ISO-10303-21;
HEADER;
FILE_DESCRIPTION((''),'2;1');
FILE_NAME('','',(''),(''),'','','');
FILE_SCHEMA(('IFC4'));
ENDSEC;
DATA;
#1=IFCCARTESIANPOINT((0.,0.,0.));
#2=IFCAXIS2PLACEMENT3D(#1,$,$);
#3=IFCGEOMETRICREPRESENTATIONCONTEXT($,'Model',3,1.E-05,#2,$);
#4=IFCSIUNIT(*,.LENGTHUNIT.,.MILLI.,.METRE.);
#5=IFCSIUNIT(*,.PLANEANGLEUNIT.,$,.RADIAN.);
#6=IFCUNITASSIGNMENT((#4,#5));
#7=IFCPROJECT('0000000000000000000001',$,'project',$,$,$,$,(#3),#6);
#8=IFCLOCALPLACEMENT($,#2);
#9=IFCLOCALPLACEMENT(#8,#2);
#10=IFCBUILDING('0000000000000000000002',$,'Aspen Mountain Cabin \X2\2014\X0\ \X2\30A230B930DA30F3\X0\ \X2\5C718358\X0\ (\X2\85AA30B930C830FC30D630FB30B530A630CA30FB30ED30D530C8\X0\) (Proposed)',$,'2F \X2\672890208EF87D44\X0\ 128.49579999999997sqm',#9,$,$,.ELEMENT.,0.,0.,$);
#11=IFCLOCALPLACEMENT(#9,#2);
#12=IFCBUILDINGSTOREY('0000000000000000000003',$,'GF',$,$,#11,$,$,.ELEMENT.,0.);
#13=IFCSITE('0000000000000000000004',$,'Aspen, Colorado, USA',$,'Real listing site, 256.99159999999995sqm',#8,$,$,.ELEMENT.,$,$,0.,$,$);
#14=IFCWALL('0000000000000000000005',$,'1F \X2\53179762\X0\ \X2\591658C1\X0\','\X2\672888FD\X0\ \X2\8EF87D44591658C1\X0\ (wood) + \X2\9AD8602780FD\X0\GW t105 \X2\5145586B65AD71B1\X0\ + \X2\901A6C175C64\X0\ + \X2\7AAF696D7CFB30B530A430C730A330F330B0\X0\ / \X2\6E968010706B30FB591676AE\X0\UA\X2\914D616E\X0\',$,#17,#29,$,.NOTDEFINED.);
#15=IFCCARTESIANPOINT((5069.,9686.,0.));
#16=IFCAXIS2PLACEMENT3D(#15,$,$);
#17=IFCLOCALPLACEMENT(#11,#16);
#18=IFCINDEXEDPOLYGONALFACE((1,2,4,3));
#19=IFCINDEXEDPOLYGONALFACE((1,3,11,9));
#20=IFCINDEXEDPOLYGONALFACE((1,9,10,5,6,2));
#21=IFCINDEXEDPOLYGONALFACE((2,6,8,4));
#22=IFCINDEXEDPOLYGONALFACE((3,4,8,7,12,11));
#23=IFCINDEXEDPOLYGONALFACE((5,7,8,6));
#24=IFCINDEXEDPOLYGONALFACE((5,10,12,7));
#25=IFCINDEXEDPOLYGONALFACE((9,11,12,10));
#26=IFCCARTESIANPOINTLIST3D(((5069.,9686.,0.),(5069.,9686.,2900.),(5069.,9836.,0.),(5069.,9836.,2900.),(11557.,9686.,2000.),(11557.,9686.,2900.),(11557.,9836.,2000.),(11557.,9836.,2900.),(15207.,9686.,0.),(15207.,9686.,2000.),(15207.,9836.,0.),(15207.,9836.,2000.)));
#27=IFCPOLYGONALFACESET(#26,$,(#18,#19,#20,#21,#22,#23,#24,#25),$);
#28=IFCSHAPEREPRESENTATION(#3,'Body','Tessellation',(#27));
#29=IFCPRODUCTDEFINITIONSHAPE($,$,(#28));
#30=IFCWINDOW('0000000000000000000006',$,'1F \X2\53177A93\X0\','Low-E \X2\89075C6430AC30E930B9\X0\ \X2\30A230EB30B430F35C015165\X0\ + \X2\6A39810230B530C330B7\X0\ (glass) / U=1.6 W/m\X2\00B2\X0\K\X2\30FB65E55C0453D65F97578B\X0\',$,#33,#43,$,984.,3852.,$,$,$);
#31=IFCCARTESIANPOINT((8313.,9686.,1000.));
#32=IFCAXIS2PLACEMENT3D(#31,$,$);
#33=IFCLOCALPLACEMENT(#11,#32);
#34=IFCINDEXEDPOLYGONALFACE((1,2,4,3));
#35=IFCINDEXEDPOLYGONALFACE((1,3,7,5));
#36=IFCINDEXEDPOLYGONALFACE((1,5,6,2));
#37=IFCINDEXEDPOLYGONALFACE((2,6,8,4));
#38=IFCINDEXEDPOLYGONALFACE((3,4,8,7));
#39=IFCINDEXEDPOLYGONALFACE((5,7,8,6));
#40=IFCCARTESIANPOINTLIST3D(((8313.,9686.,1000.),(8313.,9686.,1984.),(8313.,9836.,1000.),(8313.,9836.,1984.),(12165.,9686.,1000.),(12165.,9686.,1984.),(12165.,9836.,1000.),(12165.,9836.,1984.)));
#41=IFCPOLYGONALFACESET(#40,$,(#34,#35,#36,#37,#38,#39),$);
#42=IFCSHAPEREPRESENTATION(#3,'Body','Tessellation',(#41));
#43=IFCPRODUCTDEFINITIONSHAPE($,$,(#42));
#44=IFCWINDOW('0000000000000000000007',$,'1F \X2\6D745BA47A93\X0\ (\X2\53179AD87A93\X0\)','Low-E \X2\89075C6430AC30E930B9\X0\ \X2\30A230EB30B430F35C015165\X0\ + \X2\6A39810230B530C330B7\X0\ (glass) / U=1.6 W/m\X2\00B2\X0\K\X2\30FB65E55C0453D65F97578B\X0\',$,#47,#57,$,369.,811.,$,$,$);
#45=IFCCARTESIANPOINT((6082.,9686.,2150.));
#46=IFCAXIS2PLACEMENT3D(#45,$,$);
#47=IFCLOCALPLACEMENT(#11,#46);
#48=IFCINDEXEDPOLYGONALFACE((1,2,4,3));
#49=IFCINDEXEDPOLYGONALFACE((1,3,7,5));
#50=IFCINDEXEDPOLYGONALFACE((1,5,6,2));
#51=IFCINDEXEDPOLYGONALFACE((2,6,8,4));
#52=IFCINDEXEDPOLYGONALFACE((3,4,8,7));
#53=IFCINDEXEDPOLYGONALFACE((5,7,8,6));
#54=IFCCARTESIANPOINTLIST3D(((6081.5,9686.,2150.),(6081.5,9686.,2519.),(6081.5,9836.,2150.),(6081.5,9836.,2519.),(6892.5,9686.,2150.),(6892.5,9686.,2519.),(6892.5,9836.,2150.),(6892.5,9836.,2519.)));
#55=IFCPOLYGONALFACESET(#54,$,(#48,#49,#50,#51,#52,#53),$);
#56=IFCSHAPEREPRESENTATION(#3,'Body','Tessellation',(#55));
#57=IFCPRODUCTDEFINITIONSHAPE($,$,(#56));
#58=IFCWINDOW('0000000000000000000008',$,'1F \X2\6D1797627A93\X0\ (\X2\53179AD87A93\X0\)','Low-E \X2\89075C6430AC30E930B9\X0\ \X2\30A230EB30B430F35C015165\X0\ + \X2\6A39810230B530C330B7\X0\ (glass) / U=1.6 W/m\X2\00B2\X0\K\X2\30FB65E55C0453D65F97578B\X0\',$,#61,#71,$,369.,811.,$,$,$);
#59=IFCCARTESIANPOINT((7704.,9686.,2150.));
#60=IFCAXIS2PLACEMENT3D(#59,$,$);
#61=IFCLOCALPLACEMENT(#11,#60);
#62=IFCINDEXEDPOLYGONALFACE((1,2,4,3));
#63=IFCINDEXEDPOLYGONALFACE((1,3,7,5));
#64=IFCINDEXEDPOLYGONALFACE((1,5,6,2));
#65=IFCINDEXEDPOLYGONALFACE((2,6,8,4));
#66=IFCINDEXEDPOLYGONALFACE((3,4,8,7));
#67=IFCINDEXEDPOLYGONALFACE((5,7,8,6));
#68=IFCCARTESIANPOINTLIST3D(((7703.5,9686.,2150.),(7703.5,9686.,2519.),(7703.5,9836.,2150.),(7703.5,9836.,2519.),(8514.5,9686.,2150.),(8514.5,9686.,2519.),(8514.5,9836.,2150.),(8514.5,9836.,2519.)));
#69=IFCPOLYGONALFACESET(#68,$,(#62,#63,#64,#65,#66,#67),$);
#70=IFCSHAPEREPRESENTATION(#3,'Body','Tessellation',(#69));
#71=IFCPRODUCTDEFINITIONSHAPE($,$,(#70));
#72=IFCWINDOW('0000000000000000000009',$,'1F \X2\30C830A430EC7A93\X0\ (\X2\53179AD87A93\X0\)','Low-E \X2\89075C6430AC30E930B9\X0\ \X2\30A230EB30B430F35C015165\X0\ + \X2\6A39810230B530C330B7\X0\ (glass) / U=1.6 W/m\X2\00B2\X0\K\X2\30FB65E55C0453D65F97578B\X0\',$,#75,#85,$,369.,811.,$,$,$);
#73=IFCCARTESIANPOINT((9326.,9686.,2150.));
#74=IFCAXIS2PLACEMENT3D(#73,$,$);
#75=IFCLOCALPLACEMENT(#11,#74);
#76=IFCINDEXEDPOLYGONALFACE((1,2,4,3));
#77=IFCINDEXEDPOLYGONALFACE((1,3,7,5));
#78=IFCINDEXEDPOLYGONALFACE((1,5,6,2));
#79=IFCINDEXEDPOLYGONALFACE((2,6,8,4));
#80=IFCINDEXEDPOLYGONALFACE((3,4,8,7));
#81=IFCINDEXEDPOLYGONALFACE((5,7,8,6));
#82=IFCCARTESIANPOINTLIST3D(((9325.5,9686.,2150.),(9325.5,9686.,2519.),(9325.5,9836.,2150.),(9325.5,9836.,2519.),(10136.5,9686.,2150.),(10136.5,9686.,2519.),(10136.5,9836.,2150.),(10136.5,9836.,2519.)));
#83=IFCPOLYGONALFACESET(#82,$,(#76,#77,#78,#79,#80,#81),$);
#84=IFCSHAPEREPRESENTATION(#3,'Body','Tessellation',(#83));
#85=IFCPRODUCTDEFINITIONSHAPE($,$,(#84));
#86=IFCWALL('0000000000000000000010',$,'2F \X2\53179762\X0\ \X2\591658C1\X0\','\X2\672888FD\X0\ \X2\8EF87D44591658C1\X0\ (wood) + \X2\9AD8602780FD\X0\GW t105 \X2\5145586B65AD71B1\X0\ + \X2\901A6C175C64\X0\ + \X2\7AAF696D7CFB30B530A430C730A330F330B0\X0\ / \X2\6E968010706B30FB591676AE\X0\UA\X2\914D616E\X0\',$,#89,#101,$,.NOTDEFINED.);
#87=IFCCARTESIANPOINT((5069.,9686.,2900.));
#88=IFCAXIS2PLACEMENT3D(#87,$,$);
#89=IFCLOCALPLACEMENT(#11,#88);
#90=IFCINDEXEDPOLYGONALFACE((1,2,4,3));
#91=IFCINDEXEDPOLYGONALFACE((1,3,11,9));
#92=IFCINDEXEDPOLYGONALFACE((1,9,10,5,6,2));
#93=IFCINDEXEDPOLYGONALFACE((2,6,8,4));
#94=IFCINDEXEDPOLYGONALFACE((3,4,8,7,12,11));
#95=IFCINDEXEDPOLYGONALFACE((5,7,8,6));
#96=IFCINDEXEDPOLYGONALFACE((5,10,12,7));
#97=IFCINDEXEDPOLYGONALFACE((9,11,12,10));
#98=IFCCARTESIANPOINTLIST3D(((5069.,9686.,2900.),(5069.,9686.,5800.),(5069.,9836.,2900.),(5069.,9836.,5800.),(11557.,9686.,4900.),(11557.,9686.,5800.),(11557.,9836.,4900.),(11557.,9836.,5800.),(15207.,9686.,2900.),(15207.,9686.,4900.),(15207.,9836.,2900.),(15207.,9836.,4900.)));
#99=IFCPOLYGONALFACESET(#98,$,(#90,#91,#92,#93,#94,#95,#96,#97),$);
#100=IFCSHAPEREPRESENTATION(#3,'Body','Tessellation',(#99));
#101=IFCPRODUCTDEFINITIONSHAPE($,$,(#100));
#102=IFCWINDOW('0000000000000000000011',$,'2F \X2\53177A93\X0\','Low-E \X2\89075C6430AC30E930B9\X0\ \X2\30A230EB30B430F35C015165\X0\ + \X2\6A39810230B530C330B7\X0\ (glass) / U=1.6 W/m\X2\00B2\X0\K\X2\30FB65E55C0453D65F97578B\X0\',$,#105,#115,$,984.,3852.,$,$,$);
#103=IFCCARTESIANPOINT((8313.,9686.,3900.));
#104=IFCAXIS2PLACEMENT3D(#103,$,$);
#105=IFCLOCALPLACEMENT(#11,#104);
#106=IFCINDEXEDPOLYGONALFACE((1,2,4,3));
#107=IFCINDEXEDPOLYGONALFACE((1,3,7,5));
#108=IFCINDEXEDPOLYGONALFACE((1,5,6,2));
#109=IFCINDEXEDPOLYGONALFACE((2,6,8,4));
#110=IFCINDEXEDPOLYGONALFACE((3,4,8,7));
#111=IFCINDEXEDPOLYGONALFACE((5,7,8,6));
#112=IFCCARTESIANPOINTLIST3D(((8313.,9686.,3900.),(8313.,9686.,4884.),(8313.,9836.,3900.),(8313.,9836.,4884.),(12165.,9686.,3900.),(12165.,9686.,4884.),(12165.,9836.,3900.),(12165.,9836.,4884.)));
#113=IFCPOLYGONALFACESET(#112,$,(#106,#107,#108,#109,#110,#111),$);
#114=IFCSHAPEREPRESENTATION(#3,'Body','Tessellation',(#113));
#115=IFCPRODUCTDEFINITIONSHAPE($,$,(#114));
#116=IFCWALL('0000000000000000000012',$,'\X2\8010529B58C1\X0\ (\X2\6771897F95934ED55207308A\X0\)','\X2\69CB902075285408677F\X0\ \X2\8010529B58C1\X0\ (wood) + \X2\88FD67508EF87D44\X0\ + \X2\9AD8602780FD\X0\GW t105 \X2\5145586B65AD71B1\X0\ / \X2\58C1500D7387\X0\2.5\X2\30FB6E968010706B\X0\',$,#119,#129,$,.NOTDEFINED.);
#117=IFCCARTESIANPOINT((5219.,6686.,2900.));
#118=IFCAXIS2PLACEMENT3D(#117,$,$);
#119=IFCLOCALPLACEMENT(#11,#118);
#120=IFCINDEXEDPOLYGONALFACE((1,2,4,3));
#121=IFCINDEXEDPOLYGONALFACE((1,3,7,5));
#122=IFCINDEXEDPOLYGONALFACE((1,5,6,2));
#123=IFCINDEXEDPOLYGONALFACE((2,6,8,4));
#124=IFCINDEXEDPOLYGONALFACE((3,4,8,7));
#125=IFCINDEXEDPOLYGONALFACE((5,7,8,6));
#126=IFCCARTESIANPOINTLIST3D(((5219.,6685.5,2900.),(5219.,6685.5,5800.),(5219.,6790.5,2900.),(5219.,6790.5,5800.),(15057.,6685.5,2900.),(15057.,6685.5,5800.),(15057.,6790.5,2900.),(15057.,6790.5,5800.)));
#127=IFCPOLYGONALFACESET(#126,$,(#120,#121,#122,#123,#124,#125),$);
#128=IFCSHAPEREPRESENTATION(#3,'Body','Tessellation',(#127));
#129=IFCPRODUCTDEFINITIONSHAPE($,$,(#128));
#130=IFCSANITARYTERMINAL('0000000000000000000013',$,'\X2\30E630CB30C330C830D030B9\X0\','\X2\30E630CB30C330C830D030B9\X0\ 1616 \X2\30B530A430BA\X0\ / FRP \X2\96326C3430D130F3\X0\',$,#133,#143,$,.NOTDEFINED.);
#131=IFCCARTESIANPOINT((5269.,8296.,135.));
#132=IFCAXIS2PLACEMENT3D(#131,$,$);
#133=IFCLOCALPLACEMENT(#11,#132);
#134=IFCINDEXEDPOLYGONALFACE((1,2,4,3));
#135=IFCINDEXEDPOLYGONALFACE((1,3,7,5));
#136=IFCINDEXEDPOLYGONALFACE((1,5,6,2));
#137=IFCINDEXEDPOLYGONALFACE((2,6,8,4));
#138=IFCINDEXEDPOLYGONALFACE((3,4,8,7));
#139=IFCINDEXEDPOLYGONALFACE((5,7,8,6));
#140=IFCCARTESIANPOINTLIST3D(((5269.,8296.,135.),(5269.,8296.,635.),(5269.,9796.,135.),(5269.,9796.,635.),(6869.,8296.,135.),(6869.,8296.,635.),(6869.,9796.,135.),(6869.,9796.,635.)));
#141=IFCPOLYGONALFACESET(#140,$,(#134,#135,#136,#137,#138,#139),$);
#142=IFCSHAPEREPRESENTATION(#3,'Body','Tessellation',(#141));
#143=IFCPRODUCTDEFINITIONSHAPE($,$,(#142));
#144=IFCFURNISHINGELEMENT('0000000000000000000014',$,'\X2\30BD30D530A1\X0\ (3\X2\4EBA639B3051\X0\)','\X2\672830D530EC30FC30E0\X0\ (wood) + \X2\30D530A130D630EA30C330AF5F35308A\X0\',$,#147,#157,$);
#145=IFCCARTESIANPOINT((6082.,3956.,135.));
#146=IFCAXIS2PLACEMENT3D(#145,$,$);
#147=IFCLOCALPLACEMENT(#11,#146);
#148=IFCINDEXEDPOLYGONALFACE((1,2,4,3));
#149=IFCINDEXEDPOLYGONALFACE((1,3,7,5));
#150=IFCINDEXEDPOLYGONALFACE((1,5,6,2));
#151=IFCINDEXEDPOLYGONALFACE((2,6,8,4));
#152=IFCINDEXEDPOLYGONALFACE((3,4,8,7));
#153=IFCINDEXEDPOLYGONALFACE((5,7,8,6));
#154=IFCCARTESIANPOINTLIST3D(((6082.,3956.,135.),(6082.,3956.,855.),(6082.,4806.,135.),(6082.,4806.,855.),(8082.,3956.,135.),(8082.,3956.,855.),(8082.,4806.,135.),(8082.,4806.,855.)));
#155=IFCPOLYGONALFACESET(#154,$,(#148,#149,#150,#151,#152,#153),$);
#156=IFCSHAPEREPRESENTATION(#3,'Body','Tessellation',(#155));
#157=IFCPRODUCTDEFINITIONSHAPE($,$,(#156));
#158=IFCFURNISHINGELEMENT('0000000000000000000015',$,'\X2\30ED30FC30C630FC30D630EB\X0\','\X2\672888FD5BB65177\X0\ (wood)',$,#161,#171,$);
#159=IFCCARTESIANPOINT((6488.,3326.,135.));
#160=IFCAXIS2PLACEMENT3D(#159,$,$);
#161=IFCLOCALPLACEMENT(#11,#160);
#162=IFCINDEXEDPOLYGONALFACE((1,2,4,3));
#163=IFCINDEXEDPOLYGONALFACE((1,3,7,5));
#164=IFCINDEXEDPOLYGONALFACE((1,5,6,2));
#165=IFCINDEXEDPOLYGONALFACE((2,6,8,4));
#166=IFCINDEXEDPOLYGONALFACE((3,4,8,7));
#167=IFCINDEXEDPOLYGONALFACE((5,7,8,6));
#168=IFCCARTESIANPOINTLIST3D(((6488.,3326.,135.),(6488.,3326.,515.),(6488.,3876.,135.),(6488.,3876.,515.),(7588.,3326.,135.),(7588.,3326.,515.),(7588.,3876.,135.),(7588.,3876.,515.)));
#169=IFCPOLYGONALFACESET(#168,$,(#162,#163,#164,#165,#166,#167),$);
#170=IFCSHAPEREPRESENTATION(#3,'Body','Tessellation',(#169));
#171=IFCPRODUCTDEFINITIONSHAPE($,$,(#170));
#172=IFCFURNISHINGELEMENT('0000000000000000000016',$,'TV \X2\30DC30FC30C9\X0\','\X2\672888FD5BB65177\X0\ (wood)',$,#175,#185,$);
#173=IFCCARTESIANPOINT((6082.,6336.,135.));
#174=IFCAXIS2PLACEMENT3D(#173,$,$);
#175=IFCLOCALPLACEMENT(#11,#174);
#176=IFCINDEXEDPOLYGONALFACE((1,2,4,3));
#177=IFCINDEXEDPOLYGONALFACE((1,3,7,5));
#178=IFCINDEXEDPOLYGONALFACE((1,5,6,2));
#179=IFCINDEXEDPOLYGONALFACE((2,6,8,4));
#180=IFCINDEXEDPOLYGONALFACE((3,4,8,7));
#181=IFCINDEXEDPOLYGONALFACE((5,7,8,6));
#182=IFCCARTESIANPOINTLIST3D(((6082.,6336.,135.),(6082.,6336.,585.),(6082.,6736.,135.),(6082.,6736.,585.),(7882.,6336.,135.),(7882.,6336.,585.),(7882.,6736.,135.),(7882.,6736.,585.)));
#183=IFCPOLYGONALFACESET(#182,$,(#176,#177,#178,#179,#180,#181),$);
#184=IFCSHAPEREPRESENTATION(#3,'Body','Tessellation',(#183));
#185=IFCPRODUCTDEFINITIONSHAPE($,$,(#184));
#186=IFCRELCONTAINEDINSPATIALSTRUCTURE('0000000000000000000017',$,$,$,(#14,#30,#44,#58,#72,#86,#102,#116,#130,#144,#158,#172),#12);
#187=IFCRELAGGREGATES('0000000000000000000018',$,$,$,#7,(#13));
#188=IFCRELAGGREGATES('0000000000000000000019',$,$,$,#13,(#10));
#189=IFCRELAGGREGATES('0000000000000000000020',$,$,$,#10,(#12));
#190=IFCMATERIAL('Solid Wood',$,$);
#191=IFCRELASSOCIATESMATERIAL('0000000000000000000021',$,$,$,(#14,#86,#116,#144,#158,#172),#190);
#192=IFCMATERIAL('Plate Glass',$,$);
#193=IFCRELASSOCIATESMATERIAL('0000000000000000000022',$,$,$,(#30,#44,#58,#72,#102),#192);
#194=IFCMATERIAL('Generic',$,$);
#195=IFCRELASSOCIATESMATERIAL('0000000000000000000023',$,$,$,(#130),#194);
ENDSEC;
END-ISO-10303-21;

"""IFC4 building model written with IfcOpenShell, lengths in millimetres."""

from ifc_helpers import new_model, si_unit, frame, frame_2d, origin, place, context, project, spatial, rectangle, extrude, material, element, fill, save


model = new_model("IFC4")

# Units and contexts
model_context = context("Model", 3, precision=1e-05, world=origin())
ifc_project = project(units=[si_unit("LENGTHUNIT", "METRE", prefix="MILLI"), si_unit("PLANEANGLEUNIT", "RADIAN")], contexts=[model_context])

# Site, building, storey
site_placement = place(None, origin())
site = spatial("IfcSite", under=ifc_project, at=site_placement, Name="Aspen, Colorado, USA", ObjectType="Real listing site, 256.99159999999995sqm", CompositionType="ELEMENT", RefElevation=0.0)
building_placement = place(site_placement, origin())
building = spatial("IfcBuilding", under=site, at=building_placement, Name="Aspen Mountain Cabin — アスペン 山荘 (薪ストーブ・サウナ・ロフト) (Proposed)", ObjectType="2F 木造軸組 128.49579999999997sqm", CompositionType="ELEMENT", ElevationOfRefHeight=0.0, ElevationOfTerrain=0.0)
storey_placement = place(building_placement, origin())
storey = spatial("IfcBuildingStorey", under=building, at=storey_placement, Name="GF", CompositionType="ELEMENT", Elevation=0.0)

# Wall, openings, windows
ifc_material_1 = material(Name="Solid Wood")
wall_1_placement = place(storey_placement, frame((5069.0, 9686.0, 0.0)))
wall_1 = element("IfcWall", 1, at=wall_1_placement, inside=storey, material=ifc_material_1, Name="1F 北面 外壁", Description="木製 軸組外壁 (wood) + 高性能GW t105 充填断熱 + 通気層 + 窯業系サイディング / 準耐火・外皮UA配慮", PredefinedType="NOTDEFINED", context=model_context, shape_type="SweptSolid", body=[
    extrude(rectangle(XDim=10138.0, YDim=150.0, at=frame_2d((5069.0, 75.0))), frame((5069.0, 9686.0, 0.0)), (0.0, 0.0, 1.0), 2900.0),
])
opening_1_placement = place(storey_placement, frame((8313.0, 9686.0, 1000.0)))
opening_1 = element("IfcOpeningElement", 2, at=opening_1_placement, cuts=wall_1, PredefinedType="NOTDEFINED", context=model_context, shape_type="SweptSolid", body=[
    extrude(rectangle(XDim=3852.0, YDim=150.0, at=frame_2d((1926.0, 75.0))), frame((8313.0, 9686.0, 1000.0)), (0.0, 0.0, 1.0), 984.0),
])
opening_2_placement = place(storey_placement, frame((6082.0, 9686.0, 2150.0)))
opening_2 = element("IfcOpeningElement", 3, at=opening_2_placement, cuts=wall_1, PredefinedType="NOTDEFINED", context=model_context, shape_type="SweptSolid", body=[
    extrude(rectangle(XDim=811.0, YDim=150.0, at=frame_2d((405.0, 75.0))), frame((6082.0, 9686.0, 2150.0)), (0.0, 0.0, 1.0), 369.0),
])
opening_3_placement = place(storey_placement, frame((7704.0, 9686.0, 2150.0)))
opening_3 = element("IfcOpeningElement", 4, at=opening_3_placement, cuts=wall_1, PredefinedType="NOTDEFINED", context=model_context, shape_type="SweptSolid", body=[
    extrude(rectangle(XDim=811.0, YDim=150.0, at=frame_2d((405.0, 75.0))), frame((7704.0, 9686.0, 2150.0)), (0.0, 0.0, 1.0), 369.0),
])
opening_4_placement = place(storey_placement, frame((9326.0, 9686.0, 2150.0)))
opening_4 = element("IfcOpeningElement", 5, at=opening_4_placement, cuts=wall_1, PredefinedType="NOTDEFINED", context=model_context, shape_type="SweptSolid", body=[
    extrude(rectangle(XDim=811.0, YDim=150.0, at=frame_2d((405.0, 75.0))), frame((9326.0, 9686.0, 2150.0)), (0.0, 0.0, 1.0), 369.0),
])
ifc_material_2 = material(Name="Plate Glass")
window_1_placement = place(storey_placement, frame((8313.0, 9686.0, 1000.0)))
window_1 = element("IfcWindow", 6, at=window_1_placement, inside=storey, material=ifc_material_2, Name="1F 北窓", Description="Low-E 複層ガラス アルゴン封入 + 樹脂サッシ (glass) / U=1.6 W/m²K・日射取得型", OverallHeight=984.0, OverallWidth=3852.0, context=model_context, shape_type="SweptSolid", body=[
    extrude(rectangle(XDim=3852.0, YDim=150.0, at=frame_2d((1926.0, 75.0))), frame((8313.0, 9686.0, 1000.0)), (0.0, 0.0, 1.0), 984.0),
])
fill(opening_1, window_1)
window_2_placement = place(storey_placement, frame((6082.0, 9686.0, 2150.0)))
window_2 = element("IfcWindow", 7, at=window_2_placement, inside=storey, material=ifc_material_2, Name="1F 浴室窓 (北高窓)", Description="Low-E 複層ガラス アルゴン封入 + 樹脂サッシ (glass) / U=1.6 W/m²K・日射取得型", OverallHeight=369.0, OverallWidth=811.0, context=model_context, shape_type="SweptSolid", body=[
    extrude(rectangle(XDim=811.0, YDim=150.0, at=frame_2d((405.0, 75.0))), frame((6082.0, 9686.0, 2150.0)), (0.0, 0.0, 1.0), 369.0),
])
fill(opening_2, window_2)
window_3_placement = place(storey_placement, frame((7704.0, 9686.0, 2150.0)))
window_3 = element("IfcWindow", 8, at=window_3_placement, inside=storey, material=ifc_material_2, Name="1F 洗面窓 (北高窓)", Description="Low-E 複層ガラス アルゴン封入 + 樹脂サッシ (glass) / U=1.6 W/m²K・日射取得型", OverallHeight=369.0, OverallWidth=811.0, context=model_context, shape_type="SweptSolid", body=[
    extrude(rectangle(XDim=811.0, YDim=150.0, at=frame_2d((405.0, 75.0))), frame((7704.0, 9686.0, 2150.0)), (0.0, 0.0, 1.0), 369.0),
])
fill(opening_3, window_3)
window_4_placement = place(storey_placement, frame((9326.0, 9686.0, 2150.0)))
window_4 = element("IfcWindow", 9, at=window_4_placement, inside=storey, material=ifc_material_2, Name="1F トイレ窓 (北高窓)", Description="Low-E 複層ガラス アルゴン封入 + 樹脂サッシ (glass) / U=1.6 W/m²K・日射取得型", OverallHeight=369.0, OverallWidth=811.0, context=model_context, shape_type="SweptSolid", body=[
    extrude(rectangle(XDim=811.0, YDim=150.0, at=frame_2d((405.0, 75.0))), frame((9326.0, 9686.0, 2150.0)), (0.0, 0.0, 1.0), 369.0),
])
fill(opening_4, window_4)

# Wall, opening, window
wall_2_placement = place(storey_placement, frame((5069.0, 9686.0, 2900.0)))
wall_2 = element("IfcWall", 10, at=wall_2_placement, inside=storey, material=ifc_material_1, Name="2F 北面 外壁", Description="木製 軸組外壁 (wood) + 高性能GW t105 充填断熱 + 通気層 + 窯業系サイディング / 準耐火・外皮UA配慮", PredefinedType="NOTDEFINED", context=model_context, shape_type="SweptSolid", body=[
    extrude(rectangle(XDim=10138.0, YDim=150.0, at=frame_2d((5069.0, 75.0))), frame((5069.0, 9686.0, 2900.0)), (0.0, 0.0, 1.0), 2900.0),
])
opening_5_placement = place(storey_placement, frame((8313.0, 9686.0, 3900.0)))
opening_5 = element("IfcOpeningElement", 11, at=opening_5_placement, cuts=wall_2, PredefinedType="NOTDEFINED", context=model_context, shape_type="SweptSolid", body=[
    extrude(rectangle(XDim=3852.0, YDim=150.0, at=frame_2d((1926.0, 75.0))), frame((8313.0, 9686.0, 3900.0)), (0.0, 0.0, 1.0), 984.0),
])
window_5_placement = place(storey_placement, frame((8313.0, 9686.0, 3900.0)))
window_5 = element("IfcWindow", 12, at=window_5_placement, inside=storey, material=ifc_material_2, Name="2F 北窓", Description="Low-E 複層ガラス アルゴン封入 + 樹脂サッシ (glass) / U=1.6 W/m²K・日射取得型", OverallHeight=984.0, OverallWidth=3852.0, context=model_context, shape_type="SweptSolid", body=[
    extrude(rectangle(XDim=3852.0, YDim=150.0, at=frame_2d((1926.0, 75.0))), frame((8313.0, 9686.0, 3900.0)), (0.0, 0.0, 1.0), 984.0),
])
fill(opening_5, window_5)

# Wall
wall_3_placement = place(storey_placement, frame((5219.0, 6686.0, 2900.0)))
element("IfcWall", 13, at=wall_3_placement, inside=storey, material=ifc_material_1, Name="耐力壁 (東西間仕切り)", Description="構造用合板 耐力壁 (wood) + 製材軸組 + 高性能GW t105 充填断熱 / 壁倍率2.5・準耐火", PredefinedType="NOTDEFINED", context=model_context, shape_type="SweptSolid", body=[
    extrude(rectangle(XDim=9838.0, YDim=105.0, at=frame_2d((4919.0, 52.0))), frame((5219.0, 6686.0, 2900.0)), (0.0, 0.0, 1.0), 2900.0),
])

# Sanitary terminal
ifc_material_3 = material(Name="Generic")
sanitary_terminal_placement = place(storey_placement, frame((5269.0, 8296.0, 135.0)))
element("IfcSanitaryTerminal", 14, at=sanitary_terminal_placement, inside=storey, material=ifc_material_3, Name="ユニットバス", Description="ユニットバス 1616 サイズ / FRP 防水パン", PredefinedType="NOTDEFINED", context=model_context, shape_type="SweptSolid", body=[
    extrude(rectangle(XDim=1600.0, YDim=1500.0, at=frame_2d((800.0, 750.0))), frame((5269.0, 8296.0, 135.0)), (0.0, 0.0, 1.0), 500.0),
])

# Furnishing elements
furnishing_1_placement = place(storey_placement, frame((6082.0, 3956.0, 135.0)))
element("IfcFurnishingElement", 15, at=furnishing_1_placement, inside=storey, material=ifc_material_1, Name="ソファ (3人掛け)", Description="木フレーム (wood) + ファブリック張り", context=model_context, shape_type="SweptSolid", body=[
    extrude(rectangle(XDim=2000.0, YDim=850.0, at=frame_2d((1000.0, 425.0))), frame((6082.0, 3956.0, 135.0)), (0.0, 0.0, 1.0), 720.0),
])
furnishing_2_placement = place(storey_placement, frame((6488.0, 3326.0, 135.0)))
element("IfcFurnishingElement", 16, at=furnishing_2_placement, inside=storey, material=ifc_material_1, Name="ローテーブル", Description="木製家具 (wood)", context=model_context, shape_type="SweptSolid", body=[
    extrude(rectangle(XDim=1100.0, YDim=550.0, at=frame_2d((550.0, 275.0))), frame((6488.0, 3326.0, 135.0)), (0.0, 0.0, 1.0), 380.0),
])
furnishing_3_placement = place(storey_placement, frame((6082.0, 6336.0, 135.0)))
element("IfcFurnishingElement", 17, at=furnishing_3_placement, inside=storey, material=ifc_material_1, Name="TV ボード", Description="木製家具 (wood)", context=model_context, shape_type="SweptSolid", body=[
    extrude(rectangle(XDim=1800.0, YDim=400.0, at=frame_2d((900.0, 200.0))), frame((6082.0, 6336.0, 135.0)), (0.0, 0.0, 1.0), 450.0),
])

save(model, "model.ifc")
